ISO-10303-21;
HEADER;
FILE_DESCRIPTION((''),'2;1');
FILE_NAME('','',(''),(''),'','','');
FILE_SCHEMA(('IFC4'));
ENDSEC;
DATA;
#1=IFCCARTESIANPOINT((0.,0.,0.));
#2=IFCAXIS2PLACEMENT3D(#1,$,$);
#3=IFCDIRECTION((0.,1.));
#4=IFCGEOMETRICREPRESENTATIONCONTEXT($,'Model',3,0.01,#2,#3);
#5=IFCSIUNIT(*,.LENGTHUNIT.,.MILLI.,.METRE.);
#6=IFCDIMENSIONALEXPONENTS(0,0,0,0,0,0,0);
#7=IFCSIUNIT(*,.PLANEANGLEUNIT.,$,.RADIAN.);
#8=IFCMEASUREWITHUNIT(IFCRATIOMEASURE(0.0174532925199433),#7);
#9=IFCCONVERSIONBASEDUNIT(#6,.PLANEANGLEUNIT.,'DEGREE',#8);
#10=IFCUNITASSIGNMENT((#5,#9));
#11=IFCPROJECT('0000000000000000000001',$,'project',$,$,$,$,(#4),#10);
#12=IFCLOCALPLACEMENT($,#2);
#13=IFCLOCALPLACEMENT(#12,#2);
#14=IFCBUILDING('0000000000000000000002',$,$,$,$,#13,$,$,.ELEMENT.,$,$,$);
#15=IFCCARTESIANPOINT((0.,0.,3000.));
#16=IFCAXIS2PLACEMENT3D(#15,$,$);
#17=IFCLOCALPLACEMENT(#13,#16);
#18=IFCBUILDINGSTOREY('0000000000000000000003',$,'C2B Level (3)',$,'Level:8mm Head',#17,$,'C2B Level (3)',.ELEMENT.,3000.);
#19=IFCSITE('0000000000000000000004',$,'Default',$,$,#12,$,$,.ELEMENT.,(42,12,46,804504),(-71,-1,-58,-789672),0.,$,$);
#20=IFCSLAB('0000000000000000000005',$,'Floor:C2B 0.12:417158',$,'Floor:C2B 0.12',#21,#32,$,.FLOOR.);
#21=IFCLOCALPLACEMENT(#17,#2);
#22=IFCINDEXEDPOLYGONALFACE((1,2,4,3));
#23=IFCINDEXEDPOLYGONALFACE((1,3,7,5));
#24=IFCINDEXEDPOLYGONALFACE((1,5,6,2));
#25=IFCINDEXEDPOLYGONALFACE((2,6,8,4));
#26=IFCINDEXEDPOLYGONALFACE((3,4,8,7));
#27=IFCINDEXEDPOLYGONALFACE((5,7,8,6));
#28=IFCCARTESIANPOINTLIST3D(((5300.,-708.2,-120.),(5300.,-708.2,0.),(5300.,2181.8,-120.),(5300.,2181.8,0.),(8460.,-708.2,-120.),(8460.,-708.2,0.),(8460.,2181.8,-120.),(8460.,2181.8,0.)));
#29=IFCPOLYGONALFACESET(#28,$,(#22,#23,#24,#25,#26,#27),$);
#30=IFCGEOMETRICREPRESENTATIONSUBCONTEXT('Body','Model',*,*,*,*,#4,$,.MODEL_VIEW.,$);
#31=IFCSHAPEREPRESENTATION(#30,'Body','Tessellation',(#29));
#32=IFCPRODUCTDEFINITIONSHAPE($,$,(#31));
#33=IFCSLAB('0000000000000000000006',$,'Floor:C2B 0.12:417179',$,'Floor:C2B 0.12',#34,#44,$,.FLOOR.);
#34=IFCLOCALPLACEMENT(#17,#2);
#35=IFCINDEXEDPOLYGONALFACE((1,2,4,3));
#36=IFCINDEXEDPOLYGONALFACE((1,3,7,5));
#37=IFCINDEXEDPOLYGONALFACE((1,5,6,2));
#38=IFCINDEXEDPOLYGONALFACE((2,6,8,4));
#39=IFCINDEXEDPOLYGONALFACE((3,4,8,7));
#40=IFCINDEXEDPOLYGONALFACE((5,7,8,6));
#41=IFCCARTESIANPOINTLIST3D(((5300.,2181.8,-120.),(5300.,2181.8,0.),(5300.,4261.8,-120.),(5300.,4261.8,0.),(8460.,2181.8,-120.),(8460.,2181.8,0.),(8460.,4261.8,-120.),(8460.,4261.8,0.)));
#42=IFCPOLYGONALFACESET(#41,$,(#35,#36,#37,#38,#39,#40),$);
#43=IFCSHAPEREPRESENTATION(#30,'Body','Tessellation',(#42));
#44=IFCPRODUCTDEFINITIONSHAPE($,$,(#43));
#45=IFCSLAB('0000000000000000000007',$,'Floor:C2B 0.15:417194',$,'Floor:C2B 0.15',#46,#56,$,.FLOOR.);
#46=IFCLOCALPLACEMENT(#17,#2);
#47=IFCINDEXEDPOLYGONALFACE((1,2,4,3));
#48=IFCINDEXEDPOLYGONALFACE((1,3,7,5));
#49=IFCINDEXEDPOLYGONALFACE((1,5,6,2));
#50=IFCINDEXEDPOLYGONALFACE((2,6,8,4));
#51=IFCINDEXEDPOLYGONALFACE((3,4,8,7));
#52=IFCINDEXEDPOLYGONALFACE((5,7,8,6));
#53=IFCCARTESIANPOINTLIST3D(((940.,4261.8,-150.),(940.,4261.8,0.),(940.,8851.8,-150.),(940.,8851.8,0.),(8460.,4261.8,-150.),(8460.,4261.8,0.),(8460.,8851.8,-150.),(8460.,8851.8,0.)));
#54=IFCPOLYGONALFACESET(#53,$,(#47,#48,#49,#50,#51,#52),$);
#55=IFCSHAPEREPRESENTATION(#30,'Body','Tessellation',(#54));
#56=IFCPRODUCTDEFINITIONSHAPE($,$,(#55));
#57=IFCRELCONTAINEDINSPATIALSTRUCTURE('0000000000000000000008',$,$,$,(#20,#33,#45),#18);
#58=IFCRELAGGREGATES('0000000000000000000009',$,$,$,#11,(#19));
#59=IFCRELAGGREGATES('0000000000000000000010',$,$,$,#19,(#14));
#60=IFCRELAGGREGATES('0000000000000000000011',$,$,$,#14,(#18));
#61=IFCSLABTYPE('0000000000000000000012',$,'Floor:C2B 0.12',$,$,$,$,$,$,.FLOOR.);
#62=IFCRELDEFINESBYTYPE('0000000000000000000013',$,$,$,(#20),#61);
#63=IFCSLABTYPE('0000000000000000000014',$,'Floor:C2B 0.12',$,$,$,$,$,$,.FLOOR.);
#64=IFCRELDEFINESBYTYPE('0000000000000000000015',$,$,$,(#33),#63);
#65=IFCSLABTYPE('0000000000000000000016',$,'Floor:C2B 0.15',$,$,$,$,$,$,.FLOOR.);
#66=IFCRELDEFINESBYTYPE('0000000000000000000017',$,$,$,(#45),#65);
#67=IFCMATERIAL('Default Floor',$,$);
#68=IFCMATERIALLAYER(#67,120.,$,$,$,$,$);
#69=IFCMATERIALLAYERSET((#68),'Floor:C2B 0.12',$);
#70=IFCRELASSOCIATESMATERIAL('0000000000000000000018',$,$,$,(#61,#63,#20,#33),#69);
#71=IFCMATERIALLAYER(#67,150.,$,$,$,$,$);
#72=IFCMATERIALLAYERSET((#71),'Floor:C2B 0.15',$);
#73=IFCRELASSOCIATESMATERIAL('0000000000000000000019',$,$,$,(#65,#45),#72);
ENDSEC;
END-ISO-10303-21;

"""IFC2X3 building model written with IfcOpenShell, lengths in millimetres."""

from ifc_helpers import new_model, entity, si_unit, converted_unit, direction, frame, frame_2d, origin, origin_2d_with_axis, place, context, subcontext, project, spatial, rectangle, extrude, material, layer, layer_set, layer_usage, type_object, element, save


model = new_model("IFC2X3")

# Units and contexts
model_context = context("Model", 3, precision=0.01, world=origin(), true_north=direction((0.0, 1.0)))
body_context = subcontext(model_context, "Body", "Model", "MODEL_VIEW")
ifc_project = project(units=[si_unit("LENGTHUNIT", "METRE", prefix="MILLI"), converted_unit("PLANEANGLEUNIT", "DEGREE", entity("IfcRatioMeasure", 0.0174532925199433), si_unit("PLANEANGLEUNIT", "RADIAN"), dimensions=[0, 0, 0, 0, 0, 0, 0])], contexts=[model_context])

# Site, building, storey
site_placement = place(None, origin())
site = spatial("IfcSite", under=ifc_project, at=site_placement, Name="Default", CompositionType="ELEMENT", RefLatitude=(42, 12, 46, 804504), RefLongitude=(-71, -1, -58, -789672), RefElevation=0.0)
building_placement = place(site_placement, origin())
building = spatial("IfcBuilding", under=site, at=building_placement, CompositionType="ELEMENT")
storey_placement = place(building_placement, frame((0.0, 0.0, 3000.0)))
storey = spatial("IfcBuildingStorey", under=building, at=storey_placement, Name="C2B Level (3)", ObjectType="Level:8mm Head", LongName="C2B Level (3)", CompositionType="ELEMENT", Elevation=3000.0)

# Slabs
ifc_material_1 = material(Name="Default Floor")
ifc_layer_1 = layer(ifc_material_1, 120.0)
ifc_layer_set_1 = layer_set([ifc_layer_1], Name="Floor:C2B 0.12")
ifc_layer_usage_1 = layer_usage(ifc_layer_set_1, "AXIS3", "POSITIVE", 0.0)
slab_type_1 = type_object("IfcSlabType", Name="Floor:C2B 0.12", PredefinedType="FLOOR", material=ifc_layer_set_1)
slab_1_placement = place(storey_placement, origin())
element("IfcSlab", 1, at=slab_1_placement, inside=storey, type_object=slab_type_1, material=ifc_layer_usage_1, Name="Floor:C2B 0.12:417158", ObjectType="Floor:C2B 0.12", PredefinedType="FLOOR", context=body_context, shape_type="SweptSolid", body=[
    extrude(rectangle(XDim=2890.0, YDim=3160.0, at=origin_2d_with_axis()), frame((6880.0, 736.8, 0.0), z_axis=(0.0, 0.0, -1.0), x_axis=(0.0, 1.0, 0.0)), (0.0, 0.0, 1.0), 120.0),
])
ifc_layer_usage_2 = layer_usage(ifc_layer_set_1, "AXIS3", "POSITIVE", 0.0)
slab_type_2 = type_object("IfcSlabType", Name="Floor:C2B 0.12", PredefinedType="FLOOR", material=ifc_layer_set_1)
slab_2_placement = place(storey_placement, origin())
element("IfcSlab", 2, at=slab_2_placement, inside=storey, type_object=slab_type_2, material=ifc_layer_usage_2, Name="Floor:C2B 0.12:417179", ObjectType="Floor:C2B 0.12", PredefinedType="FLOOR", context=body_context, shape_type="SweptSolid", body=[
    extrude(rectangle(XDim=2080.0, YDim=3160.0, at=frame_2d((0.0, 0.0), x_axis=(1.0, 0.0))), frame((6880.0, 3221.8, 0.0), z_axis=(0.0, 0.0, -1.0), x_axis=(0.0, 1.0, 0.0)), (0.0, 0.0, 1.0), 120.0),
])
ifc_layer_2 = layer(ifc_material_1, 150.0)
ifc_layer_set_2 = layer_set([ifc_layer_2], Name="Floor:C2B 0.15")
ifc_layer_usage_3 = layer_usage(ifc_layer_set_2, "AXIS3", "POSITIVE", 0.0)
slab_type_3 = type_object("IfcSlabType", Name="Floor:C2B 0.15", PredefinedType="FLOOR", material=ifc_layer_set_2)
slab_3_placement = place(storey_placement, origin())
element("IfcSlab", 3, at=slab_3_placement, inside=storey, type_object=slab_type_3, material=ifc_layer_usage_3, Name="Floor:C2B 0.15:417194", ObjectType="Floor:C2B 0.15", PredefinedType="FLOOR", context=body_context, shape_type="SweptSolid", body=[
    extrude(rectangle(XDim=4590.0, YDim=7520.0, at=frame_2d((0.0, 0.0), x_axis=(1.0, 0.0))), frame((4700.0, 6556.8, 0.0), z_axis=(0.0, 0.0, -1.0), x_axis=(0.0, 1.0, 0.0)), (0.0, 0.0, 1.0), 150.0),
])

save(model, "model.ifc")
